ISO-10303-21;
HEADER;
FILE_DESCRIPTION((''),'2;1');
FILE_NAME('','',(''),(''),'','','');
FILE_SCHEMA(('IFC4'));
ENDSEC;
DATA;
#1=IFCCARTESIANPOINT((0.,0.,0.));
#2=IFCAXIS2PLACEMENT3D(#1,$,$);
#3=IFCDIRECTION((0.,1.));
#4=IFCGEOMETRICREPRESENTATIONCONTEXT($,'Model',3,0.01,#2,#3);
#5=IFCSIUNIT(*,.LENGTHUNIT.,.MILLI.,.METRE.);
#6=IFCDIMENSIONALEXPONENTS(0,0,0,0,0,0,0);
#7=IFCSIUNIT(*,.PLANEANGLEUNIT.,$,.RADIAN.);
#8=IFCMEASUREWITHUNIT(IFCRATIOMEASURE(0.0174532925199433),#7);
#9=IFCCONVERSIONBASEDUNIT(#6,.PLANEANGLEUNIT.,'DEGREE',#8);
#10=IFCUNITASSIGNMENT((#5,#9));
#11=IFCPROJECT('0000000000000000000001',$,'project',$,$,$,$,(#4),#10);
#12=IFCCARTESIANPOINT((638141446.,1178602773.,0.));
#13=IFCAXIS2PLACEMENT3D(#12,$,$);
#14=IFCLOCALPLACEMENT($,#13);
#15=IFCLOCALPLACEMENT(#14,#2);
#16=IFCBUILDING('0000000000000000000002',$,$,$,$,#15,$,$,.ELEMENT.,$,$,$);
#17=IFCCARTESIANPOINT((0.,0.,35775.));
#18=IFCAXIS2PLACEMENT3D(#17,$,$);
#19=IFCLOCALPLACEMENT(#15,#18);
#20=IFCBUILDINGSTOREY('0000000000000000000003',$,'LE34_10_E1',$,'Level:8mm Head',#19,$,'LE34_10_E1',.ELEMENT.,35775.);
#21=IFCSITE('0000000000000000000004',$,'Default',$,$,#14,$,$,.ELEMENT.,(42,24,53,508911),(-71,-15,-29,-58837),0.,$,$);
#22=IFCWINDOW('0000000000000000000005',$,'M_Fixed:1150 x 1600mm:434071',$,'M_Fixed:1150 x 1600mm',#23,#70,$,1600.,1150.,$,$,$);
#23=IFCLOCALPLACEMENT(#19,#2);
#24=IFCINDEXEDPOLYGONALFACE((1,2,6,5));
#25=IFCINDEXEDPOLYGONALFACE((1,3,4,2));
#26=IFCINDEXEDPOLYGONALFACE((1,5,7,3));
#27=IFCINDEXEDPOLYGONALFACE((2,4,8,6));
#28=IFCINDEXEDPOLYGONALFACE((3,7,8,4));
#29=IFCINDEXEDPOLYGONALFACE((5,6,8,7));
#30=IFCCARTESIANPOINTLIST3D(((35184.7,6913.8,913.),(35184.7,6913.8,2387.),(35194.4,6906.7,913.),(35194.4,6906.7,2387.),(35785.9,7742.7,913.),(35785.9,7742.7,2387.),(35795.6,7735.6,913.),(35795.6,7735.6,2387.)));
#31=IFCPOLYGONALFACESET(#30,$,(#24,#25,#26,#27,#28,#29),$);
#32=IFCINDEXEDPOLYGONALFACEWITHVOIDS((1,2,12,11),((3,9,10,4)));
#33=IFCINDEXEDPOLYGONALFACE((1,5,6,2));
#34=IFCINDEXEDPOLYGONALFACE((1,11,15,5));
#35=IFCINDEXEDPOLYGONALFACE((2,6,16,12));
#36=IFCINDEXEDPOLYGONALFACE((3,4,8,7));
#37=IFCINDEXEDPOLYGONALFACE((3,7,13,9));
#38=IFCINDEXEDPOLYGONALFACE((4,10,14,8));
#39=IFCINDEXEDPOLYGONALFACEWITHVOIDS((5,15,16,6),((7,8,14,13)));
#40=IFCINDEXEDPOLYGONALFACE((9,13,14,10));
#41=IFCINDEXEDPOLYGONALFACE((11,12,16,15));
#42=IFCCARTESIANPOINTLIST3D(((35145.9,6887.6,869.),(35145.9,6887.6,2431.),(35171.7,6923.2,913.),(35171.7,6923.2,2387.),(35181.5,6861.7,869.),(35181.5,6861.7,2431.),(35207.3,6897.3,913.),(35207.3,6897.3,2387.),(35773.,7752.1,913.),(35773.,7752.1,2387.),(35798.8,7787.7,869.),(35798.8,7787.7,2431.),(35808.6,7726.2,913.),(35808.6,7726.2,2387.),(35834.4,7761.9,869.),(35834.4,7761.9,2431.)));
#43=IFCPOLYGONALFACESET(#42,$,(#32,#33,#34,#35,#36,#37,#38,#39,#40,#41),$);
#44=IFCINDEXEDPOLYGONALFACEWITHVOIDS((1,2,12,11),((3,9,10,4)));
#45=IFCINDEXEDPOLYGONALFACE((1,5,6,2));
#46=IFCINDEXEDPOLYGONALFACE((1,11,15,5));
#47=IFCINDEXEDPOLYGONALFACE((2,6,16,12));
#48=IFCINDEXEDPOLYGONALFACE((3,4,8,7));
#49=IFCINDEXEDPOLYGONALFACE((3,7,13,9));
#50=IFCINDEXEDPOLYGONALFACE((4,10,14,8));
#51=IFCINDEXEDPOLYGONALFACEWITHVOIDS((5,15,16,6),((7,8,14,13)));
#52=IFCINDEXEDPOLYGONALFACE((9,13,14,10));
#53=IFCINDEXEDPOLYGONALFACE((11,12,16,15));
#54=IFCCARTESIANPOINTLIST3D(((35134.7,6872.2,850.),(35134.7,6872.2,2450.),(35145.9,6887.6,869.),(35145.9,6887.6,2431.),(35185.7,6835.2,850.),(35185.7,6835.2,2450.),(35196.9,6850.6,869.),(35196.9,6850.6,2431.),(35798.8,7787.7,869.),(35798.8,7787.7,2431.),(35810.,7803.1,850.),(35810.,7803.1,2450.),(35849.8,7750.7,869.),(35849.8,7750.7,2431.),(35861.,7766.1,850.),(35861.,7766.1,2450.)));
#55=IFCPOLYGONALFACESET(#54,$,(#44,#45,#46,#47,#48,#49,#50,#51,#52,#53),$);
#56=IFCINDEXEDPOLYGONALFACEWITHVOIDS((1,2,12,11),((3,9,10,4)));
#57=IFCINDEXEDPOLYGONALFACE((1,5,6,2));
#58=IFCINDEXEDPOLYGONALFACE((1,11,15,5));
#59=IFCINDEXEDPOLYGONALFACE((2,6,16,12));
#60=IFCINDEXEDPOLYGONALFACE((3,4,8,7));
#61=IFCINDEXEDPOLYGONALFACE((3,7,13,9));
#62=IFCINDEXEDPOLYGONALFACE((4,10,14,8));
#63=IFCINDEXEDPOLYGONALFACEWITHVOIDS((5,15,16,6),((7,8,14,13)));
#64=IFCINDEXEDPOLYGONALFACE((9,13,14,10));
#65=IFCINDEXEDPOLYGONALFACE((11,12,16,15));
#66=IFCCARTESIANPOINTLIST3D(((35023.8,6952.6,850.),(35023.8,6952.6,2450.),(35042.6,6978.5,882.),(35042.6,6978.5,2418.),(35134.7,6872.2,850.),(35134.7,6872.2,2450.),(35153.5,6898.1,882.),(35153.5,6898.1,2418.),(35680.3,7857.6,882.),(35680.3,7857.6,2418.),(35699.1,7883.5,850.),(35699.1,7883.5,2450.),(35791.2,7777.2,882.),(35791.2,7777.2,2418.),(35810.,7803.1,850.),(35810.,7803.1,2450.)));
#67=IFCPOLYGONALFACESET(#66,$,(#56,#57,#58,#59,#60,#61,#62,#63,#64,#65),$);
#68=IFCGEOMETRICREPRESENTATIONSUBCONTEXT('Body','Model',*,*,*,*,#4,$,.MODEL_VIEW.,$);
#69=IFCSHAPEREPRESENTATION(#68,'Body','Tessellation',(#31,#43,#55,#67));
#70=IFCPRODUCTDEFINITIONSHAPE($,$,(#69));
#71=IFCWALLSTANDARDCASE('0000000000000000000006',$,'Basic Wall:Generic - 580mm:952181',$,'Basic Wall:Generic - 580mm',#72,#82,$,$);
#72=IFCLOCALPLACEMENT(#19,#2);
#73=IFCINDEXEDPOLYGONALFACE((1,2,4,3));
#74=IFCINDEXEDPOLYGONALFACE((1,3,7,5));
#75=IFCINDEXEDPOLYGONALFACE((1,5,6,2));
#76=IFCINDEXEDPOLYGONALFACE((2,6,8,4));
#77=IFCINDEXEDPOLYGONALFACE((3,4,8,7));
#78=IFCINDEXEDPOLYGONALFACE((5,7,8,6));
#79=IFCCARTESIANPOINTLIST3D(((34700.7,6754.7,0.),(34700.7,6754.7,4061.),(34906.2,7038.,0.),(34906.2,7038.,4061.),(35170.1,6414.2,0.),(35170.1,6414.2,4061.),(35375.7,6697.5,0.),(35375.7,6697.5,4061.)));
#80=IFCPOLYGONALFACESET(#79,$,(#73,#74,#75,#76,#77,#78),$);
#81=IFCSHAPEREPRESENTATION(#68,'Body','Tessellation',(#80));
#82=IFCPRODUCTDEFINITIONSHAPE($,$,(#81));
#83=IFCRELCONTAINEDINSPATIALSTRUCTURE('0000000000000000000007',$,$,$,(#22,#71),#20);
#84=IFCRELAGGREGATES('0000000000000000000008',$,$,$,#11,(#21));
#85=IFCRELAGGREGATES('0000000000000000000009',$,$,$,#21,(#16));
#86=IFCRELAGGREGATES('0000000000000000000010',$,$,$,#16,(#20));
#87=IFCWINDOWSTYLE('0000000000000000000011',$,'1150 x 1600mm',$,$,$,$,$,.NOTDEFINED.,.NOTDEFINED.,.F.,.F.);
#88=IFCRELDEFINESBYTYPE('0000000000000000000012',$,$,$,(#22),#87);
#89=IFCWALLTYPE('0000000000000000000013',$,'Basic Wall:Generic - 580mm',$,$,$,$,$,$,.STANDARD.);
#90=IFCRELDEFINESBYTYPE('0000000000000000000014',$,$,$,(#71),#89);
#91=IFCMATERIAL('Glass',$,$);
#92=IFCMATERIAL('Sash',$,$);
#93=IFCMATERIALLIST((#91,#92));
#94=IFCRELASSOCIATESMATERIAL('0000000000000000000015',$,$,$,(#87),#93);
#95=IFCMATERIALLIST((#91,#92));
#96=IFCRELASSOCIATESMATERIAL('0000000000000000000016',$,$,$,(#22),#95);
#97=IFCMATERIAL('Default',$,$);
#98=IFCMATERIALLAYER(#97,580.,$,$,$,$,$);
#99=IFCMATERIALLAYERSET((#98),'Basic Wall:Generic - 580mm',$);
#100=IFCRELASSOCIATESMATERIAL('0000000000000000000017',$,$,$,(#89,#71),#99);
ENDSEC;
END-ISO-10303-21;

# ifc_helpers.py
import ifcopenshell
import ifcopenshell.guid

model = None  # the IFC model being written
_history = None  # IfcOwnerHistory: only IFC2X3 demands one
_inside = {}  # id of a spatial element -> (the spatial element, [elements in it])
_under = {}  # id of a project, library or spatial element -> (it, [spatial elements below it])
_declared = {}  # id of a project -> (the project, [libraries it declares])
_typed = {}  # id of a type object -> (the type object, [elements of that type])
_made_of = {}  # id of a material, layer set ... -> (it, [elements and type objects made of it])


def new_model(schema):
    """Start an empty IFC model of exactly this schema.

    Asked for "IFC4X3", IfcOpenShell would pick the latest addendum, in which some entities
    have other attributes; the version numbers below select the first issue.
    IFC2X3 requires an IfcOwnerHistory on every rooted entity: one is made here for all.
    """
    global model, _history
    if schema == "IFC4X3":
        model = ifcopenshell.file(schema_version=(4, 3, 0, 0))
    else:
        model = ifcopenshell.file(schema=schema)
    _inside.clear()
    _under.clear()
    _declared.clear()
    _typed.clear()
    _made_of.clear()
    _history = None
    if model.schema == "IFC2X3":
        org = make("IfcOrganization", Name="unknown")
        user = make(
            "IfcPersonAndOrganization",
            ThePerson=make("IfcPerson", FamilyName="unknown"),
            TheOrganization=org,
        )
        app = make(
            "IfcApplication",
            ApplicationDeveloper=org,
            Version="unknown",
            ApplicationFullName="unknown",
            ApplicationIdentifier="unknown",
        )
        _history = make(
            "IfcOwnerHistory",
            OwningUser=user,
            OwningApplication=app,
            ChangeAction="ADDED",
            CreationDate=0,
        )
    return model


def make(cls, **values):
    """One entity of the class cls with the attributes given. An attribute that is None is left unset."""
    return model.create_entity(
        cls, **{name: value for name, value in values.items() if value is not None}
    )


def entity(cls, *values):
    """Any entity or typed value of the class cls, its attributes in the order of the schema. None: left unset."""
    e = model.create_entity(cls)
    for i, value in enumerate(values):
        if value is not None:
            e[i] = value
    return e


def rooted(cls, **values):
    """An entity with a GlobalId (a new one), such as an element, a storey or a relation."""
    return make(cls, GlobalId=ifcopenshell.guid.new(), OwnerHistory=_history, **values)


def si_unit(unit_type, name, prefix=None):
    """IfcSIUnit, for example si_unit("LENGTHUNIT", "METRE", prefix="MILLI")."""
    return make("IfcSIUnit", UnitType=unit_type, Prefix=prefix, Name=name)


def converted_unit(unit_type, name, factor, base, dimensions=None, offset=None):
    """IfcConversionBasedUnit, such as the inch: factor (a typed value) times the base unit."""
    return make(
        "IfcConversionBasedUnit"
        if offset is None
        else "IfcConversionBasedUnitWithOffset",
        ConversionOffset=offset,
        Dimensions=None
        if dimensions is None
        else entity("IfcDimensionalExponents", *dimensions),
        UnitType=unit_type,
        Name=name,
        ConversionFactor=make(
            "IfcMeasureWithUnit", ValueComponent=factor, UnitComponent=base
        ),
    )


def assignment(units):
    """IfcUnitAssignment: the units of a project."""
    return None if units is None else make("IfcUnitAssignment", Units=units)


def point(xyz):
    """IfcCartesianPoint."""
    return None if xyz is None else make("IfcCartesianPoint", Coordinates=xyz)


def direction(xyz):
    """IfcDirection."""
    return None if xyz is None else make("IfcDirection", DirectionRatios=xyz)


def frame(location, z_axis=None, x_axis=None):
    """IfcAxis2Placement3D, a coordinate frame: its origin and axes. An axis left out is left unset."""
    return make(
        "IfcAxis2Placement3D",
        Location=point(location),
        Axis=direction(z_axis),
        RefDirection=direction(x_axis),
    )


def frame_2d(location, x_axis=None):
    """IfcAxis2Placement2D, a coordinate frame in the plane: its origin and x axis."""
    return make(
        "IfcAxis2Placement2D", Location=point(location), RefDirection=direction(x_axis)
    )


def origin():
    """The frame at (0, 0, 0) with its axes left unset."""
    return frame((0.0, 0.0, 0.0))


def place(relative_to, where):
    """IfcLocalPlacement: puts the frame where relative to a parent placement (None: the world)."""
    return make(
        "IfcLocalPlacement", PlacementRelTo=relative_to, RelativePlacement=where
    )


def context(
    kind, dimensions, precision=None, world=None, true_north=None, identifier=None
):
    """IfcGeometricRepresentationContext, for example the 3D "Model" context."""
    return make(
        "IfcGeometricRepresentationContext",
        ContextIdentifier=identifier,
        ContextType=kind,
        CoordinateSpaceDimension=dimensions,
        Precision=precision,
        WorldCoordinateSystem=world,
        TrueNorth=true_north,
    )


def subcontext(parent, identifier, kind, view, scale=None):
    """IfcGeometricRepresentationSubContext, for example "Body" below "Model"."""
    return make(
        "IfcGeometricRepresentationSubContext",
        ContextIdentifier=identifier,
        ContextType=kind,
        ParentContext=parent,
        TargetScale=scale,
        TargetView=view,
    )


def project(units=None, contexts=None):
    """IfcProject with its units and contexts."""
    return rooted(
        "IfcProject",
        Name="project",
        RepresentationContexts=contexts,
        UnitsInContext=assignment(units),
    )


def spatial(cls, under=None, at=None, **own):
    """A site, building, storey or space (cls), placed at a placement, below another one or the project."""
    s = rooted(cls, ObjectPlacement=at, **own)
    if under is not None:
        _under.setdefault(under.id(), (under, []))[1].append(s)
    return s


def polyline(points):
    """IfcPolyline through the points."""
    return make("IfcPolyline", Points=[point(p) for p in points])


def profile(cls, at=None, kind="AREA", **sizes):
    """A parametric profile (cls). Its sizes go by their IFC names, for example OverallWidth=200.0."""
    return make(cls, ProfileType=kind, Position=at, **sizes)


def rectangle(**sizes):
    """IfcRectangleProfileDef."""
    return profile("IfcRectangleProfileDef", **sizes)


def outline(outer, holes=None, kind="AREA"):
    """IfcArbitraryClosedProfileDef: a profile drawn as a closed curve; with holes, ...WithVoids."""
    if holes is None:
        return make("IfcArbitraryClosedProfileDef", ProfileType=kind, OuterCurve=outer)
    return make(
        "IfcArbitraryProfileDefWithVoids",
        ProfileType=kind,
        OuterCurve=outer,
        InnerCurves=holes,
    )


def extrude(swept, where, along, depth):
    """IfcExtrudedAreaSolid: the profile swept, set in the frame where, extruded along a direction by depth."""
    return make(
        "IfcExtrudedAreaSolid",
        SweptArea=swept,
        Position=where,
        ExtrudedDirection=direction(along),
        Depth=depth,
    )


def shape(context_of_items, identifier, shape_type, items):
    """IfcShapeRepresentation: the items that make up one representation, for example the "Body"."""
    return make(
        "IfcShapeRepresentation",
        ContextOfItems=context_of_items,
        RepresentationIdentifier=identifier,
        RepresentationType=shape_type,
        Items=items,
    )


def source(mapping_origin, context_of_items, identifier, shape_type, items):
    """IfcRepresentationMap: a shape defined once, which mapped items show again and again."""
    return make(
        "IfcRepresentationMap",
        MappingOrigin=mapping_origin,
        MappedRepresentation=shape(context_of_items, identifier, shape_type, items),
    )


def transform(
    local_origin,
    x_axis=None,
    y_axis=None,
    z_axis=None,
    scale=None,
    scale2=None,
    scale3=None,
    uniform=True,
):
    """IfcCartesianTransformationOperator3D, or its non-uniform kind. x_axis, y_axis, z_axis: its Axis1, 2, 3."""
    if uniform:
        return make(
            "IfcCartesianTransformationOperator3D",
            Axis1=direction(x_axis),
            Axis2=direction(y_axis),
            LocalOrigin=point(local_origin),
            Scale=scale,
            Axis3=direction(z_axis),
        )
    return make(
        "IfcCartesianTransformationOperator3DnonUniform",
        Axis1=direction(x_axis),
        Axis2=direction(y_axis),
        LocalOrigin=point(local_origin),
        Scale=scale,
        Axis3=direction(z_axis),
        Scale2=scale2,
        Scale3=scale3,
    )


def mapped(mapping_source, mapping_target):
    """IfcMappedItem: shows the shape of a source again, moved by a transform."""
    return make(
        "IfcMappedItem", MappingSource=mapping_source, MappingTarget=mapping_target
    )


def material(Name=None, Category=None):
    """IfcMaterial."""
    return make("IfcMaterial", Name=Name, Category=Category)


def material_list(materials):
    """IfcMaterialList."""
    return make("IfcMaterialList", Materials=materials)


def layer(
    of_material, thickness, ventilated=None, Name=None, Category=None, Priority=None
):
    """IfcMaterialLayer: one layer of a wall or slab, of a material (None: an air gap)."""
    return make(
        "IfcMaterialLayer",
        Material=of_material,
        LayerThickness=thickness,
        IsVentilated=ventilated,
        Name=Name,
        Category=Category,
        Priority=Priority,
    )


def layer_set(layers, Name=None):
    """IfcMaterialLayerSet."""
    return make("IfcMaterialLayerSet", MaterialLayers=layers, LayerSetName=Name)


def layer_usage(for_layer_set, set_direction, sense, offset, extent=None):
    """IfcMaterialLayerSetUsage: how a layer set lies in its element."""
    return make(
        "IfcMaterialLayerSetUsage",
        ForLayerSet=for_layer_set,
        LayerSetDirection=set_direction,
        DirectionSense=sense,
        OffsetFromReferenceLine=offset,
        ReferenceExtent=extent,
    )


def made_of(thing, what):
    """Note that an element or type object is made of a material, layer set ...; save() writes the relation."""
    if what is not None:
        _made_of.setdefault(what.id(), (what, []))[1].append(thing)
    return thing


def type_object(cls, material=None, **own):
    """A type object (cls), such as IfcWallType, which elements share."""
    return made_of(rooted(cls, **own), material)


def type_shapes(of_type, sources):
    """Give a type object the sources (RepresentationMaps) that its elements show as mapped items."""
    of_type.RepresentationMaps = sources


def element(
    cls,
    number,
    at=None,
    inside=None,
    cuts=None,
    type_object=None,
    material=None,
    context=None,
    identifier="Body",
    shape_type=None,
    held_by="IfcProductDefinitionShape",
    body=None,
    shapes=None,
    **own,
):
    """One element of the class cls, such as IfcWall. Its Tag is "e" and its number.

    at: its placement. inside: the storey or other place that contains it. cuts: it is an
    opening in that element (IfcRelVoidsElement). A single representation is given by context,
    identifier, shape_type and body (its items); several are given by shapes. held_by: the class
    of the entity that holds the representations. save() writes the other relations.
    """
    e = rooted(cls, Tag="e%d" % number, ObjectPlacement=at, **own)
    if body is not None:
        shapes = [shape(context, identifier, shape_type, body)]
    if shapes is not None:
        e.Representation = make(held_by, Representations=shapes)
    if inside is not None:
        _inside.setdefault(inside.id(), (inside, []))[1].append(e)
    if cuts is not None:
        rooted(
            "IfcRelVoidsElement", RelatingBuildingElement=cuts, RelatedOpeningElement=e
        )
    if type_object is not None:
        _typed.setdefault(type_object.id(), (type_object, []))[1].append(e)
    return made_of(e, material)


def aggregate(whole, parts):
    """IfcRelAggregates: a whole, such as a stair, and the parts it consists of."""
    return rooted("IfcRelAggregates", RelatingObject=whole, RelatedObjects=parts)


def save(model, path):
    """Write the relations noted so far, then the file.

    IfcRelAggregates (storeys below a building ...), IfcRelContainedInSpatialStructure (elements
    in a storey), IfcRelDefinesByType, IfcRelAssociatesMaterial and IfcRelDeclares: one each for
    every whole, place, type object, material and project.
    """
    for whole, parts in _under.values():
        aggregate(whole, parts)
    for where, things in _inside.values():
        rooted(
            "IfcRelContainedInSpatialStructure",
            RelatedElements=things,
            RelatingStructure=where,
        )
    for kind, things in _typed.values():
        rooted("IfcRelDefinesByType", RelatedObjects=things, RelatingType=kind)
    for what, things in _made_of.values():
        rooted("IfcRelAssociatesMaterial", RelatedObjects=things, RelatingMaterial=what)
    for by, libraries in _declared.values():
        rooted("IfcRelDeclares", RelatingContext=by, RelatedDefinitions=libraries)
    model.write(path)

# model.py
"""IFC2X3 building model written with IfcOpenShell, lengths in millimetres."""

from ifc_helpers import new_model, entity, si_unit, converted_unit, direction, frame, frame_2d, origin, place, context, subcontext, project, spatial, polyline, rectangle, outline, extrude, source, transform, mapped, material, material_list, layer, layer_set, layer_usage, type_object, type_shapes, element, save


model = new_model("IFC2X3")

# Units and contexts
model_context = context("Model", 3, precision=0.01, world=origin(), true_north=direction((0.0, 1.0)))
body_context = subcontext(model_context, "Body", "Model", "MODEL_VIEW")
ifc_project = project(units=[si_unit("LENGTHUNIT", "METRE", prefix="MILLI"), converted_unit("PLANEANGLEUNIT", "DEGREE", entity("IfcRatioMeasure", 0.0174532925199433), si_unit("PLANEANGLEUNIT", "RADIAN"), dimensions=[0, 0, 0, 0, 0, 0, 0])], contexts=[model_context])

# Site, building, storey
site_placement = place(None, frame((638141446.0, 1178602773.0, 0.0)))
site = spatial("IfcSite", under=ifc_project, at=site_placement, Name="Default", CompositionType="ELEMENT", RefLatitude=(42, 24, 53, 508911), RefLongitude=(-71, -15, -29, -58837), RefElevation=0.0)
building_placement = place(site_placement, origin())
building = spatial("IfcBuilding", under=site, at=building_placement, CompositionType="ELEMENT")
storey_placement = place(building_placement, frame((0.0, 0.0, 35775.0)))
storey = spatial("IfcBuildingStorey", under=building, at=storey_placement, Name="LE34_10_E1", ObjectType="Level:8mm Head", LongName="LE34_10_E1", CompositionType="ELEMENT", Elevation=35775.0)

# Shared definitions
ifc_material_1 = material(Name="Default")

# Window
ifc_material_2 = material(Name="Glass")
ifc_material_3 = material(Name="Sash")
ifc_material_list_1 = material_list([ifc_material_2, ifc_material_3])
window_style = type_object("IfcWindowStyle", Name="1150 x 1600mm", ConstructionType="NOTDEFINED", OperationType="NOTDEFINED", ParameterTakesPrecedence=False, Sizeable=False, material=ifc_material_list_1)
shared_shape = source(origin(), body_context, "Body", "SweptSolid", [
    extrude(rectangle(XDim=1024.0, YDim=12.0, at=frame_2d((0.0, 0.0), x_axis=(1.0, 0.0))), frame((575.0, 295.0, 63.0), z_axis=(0.0, 0.0, 1.0), x_axis=(-1.0, 0.0, 0.0)), (0.0, 0.0, 1.0), 1474.0),
    extrude(outline(polyline([(-556.0, -781.0), (556.0, -781.0), (556.0, 781.0), (-556.0, 781.0), (-556.0, -781.0)]), holes=[polyline([(-512.0, -737.0), (-512.0, 737.0), (512.0, 737.0), (512.0, -737.0), (-512.0, -737.0)])]), frame((575.0, 317.0, 800.0), z_axis=(0.0, -1.0, 0.0), x_axis=(-1.0, 0.0, 0.0)), (0.0, 0.0, 1.0), 44.0),
    extrude(outline(polyline([(-575.0, -800.0), (575.0, -800.0), (575.0, 800.0), (-575.0, 800.0), (-575.0, -800.0)]), holes=[polyline([(-556.0, -781.0), (-556.0, 781.0), (556.0, 781.0), (556.0, -781.0), (-556.0, -781.0)])]), frame((575.0, 336.0, 800.0), z_axis=(0.0, -1.0, 0.0), x_axis=(-1.0, 0.0, 0.0)), (0.0, 0.0, 1.0), 63.0),
    extrude(outline(polyline([(-575.0, -800.0), (575.0, -800.0), (575.0, 800.0), (-575.0, 800.0), (-575.0, -800.0)]), holes=[polyline([(-543.0, -768.0), (-543.0, 768.0), (543.0, 768.0), (543.0, -768.0), (-543.0, -768.0)])]), frame((575.0, 273.0, 800.0), z_axis=(0.0, -1.0, 0.0), x_axis=(-1.0, 0.0, 0.0)), (0.0, 0.0, 1.0), 137.0),
])
type_shapes(window_style, [shared_shape])
ifc_material_list_2 = material_list([ifc_material_2, ifc_material_3])
window_1_placement = place(storey_placement, frame((35589.0, 7963.4, 850.0), z_axis=(0.0, 0.0, 1.0), x_axis=(-0.587164, -0.809468, 0.0)))
element("IfcWindow", 1, at=window_1_placement, inside=storey, type_object=window_style, material=ifc_material_list_2, Name="M_Fixed:1150 x 1600mm:434071", ObjectType="M_Fixed:1150 x 1600mm", OverallHeight=1600.0, OverallWidth=1150.0, context=body_context, shape_type="MappedRepresentation", body=[
    mapped(shared_shape, transform((0.0, 0.0, 0.0), scale=1.0)),
])

# Shared definitions
ifc_layer_1 = layer(ifc_material_1, 580.0)
ifc_layer_set_1 = layer_set([ifc_layer_1], Name="Basic Wall:Generic - 580mm")
wall_type_1 = type_object("IfcWallType", Name="Basic Wall:Generic - 580mm", PredefinedType="STANDARD", material=ifc_layer_set_1)

# Wall
ifc_layer_usage_1 = layer_usage(ifc_layer_set_1, "AXIS2", "NEGATIVE", 290.0)
wall_1_placement = place(storey_placement, frame((35140.9, 6867.8, 0.0), z_axis=(0.0, 0.0, 1.0), x_axis=(-0.587164, -0.809468, 0.0)))
element("IfcWallStandardCase", 2, at=wall_1_placement, inside=storey, type_object=wall_type_1, material=ifc_layer_usage_1, Name="Basic Wall:Generic - 580mm:952181", ObjectType="Basic Wall:Generic - 580mm", context=body_context, shape_type="SweptSolid", body=[
    extrude(rectangle(XDim=350.0, YDim=580.0, at=frame_2d((175.0, 0.0), x_axis=(-1.0, 0.0))), origin(), (0.0, 0.0, 1.0), 4061.0),
])

save(model, "model.ifc")
